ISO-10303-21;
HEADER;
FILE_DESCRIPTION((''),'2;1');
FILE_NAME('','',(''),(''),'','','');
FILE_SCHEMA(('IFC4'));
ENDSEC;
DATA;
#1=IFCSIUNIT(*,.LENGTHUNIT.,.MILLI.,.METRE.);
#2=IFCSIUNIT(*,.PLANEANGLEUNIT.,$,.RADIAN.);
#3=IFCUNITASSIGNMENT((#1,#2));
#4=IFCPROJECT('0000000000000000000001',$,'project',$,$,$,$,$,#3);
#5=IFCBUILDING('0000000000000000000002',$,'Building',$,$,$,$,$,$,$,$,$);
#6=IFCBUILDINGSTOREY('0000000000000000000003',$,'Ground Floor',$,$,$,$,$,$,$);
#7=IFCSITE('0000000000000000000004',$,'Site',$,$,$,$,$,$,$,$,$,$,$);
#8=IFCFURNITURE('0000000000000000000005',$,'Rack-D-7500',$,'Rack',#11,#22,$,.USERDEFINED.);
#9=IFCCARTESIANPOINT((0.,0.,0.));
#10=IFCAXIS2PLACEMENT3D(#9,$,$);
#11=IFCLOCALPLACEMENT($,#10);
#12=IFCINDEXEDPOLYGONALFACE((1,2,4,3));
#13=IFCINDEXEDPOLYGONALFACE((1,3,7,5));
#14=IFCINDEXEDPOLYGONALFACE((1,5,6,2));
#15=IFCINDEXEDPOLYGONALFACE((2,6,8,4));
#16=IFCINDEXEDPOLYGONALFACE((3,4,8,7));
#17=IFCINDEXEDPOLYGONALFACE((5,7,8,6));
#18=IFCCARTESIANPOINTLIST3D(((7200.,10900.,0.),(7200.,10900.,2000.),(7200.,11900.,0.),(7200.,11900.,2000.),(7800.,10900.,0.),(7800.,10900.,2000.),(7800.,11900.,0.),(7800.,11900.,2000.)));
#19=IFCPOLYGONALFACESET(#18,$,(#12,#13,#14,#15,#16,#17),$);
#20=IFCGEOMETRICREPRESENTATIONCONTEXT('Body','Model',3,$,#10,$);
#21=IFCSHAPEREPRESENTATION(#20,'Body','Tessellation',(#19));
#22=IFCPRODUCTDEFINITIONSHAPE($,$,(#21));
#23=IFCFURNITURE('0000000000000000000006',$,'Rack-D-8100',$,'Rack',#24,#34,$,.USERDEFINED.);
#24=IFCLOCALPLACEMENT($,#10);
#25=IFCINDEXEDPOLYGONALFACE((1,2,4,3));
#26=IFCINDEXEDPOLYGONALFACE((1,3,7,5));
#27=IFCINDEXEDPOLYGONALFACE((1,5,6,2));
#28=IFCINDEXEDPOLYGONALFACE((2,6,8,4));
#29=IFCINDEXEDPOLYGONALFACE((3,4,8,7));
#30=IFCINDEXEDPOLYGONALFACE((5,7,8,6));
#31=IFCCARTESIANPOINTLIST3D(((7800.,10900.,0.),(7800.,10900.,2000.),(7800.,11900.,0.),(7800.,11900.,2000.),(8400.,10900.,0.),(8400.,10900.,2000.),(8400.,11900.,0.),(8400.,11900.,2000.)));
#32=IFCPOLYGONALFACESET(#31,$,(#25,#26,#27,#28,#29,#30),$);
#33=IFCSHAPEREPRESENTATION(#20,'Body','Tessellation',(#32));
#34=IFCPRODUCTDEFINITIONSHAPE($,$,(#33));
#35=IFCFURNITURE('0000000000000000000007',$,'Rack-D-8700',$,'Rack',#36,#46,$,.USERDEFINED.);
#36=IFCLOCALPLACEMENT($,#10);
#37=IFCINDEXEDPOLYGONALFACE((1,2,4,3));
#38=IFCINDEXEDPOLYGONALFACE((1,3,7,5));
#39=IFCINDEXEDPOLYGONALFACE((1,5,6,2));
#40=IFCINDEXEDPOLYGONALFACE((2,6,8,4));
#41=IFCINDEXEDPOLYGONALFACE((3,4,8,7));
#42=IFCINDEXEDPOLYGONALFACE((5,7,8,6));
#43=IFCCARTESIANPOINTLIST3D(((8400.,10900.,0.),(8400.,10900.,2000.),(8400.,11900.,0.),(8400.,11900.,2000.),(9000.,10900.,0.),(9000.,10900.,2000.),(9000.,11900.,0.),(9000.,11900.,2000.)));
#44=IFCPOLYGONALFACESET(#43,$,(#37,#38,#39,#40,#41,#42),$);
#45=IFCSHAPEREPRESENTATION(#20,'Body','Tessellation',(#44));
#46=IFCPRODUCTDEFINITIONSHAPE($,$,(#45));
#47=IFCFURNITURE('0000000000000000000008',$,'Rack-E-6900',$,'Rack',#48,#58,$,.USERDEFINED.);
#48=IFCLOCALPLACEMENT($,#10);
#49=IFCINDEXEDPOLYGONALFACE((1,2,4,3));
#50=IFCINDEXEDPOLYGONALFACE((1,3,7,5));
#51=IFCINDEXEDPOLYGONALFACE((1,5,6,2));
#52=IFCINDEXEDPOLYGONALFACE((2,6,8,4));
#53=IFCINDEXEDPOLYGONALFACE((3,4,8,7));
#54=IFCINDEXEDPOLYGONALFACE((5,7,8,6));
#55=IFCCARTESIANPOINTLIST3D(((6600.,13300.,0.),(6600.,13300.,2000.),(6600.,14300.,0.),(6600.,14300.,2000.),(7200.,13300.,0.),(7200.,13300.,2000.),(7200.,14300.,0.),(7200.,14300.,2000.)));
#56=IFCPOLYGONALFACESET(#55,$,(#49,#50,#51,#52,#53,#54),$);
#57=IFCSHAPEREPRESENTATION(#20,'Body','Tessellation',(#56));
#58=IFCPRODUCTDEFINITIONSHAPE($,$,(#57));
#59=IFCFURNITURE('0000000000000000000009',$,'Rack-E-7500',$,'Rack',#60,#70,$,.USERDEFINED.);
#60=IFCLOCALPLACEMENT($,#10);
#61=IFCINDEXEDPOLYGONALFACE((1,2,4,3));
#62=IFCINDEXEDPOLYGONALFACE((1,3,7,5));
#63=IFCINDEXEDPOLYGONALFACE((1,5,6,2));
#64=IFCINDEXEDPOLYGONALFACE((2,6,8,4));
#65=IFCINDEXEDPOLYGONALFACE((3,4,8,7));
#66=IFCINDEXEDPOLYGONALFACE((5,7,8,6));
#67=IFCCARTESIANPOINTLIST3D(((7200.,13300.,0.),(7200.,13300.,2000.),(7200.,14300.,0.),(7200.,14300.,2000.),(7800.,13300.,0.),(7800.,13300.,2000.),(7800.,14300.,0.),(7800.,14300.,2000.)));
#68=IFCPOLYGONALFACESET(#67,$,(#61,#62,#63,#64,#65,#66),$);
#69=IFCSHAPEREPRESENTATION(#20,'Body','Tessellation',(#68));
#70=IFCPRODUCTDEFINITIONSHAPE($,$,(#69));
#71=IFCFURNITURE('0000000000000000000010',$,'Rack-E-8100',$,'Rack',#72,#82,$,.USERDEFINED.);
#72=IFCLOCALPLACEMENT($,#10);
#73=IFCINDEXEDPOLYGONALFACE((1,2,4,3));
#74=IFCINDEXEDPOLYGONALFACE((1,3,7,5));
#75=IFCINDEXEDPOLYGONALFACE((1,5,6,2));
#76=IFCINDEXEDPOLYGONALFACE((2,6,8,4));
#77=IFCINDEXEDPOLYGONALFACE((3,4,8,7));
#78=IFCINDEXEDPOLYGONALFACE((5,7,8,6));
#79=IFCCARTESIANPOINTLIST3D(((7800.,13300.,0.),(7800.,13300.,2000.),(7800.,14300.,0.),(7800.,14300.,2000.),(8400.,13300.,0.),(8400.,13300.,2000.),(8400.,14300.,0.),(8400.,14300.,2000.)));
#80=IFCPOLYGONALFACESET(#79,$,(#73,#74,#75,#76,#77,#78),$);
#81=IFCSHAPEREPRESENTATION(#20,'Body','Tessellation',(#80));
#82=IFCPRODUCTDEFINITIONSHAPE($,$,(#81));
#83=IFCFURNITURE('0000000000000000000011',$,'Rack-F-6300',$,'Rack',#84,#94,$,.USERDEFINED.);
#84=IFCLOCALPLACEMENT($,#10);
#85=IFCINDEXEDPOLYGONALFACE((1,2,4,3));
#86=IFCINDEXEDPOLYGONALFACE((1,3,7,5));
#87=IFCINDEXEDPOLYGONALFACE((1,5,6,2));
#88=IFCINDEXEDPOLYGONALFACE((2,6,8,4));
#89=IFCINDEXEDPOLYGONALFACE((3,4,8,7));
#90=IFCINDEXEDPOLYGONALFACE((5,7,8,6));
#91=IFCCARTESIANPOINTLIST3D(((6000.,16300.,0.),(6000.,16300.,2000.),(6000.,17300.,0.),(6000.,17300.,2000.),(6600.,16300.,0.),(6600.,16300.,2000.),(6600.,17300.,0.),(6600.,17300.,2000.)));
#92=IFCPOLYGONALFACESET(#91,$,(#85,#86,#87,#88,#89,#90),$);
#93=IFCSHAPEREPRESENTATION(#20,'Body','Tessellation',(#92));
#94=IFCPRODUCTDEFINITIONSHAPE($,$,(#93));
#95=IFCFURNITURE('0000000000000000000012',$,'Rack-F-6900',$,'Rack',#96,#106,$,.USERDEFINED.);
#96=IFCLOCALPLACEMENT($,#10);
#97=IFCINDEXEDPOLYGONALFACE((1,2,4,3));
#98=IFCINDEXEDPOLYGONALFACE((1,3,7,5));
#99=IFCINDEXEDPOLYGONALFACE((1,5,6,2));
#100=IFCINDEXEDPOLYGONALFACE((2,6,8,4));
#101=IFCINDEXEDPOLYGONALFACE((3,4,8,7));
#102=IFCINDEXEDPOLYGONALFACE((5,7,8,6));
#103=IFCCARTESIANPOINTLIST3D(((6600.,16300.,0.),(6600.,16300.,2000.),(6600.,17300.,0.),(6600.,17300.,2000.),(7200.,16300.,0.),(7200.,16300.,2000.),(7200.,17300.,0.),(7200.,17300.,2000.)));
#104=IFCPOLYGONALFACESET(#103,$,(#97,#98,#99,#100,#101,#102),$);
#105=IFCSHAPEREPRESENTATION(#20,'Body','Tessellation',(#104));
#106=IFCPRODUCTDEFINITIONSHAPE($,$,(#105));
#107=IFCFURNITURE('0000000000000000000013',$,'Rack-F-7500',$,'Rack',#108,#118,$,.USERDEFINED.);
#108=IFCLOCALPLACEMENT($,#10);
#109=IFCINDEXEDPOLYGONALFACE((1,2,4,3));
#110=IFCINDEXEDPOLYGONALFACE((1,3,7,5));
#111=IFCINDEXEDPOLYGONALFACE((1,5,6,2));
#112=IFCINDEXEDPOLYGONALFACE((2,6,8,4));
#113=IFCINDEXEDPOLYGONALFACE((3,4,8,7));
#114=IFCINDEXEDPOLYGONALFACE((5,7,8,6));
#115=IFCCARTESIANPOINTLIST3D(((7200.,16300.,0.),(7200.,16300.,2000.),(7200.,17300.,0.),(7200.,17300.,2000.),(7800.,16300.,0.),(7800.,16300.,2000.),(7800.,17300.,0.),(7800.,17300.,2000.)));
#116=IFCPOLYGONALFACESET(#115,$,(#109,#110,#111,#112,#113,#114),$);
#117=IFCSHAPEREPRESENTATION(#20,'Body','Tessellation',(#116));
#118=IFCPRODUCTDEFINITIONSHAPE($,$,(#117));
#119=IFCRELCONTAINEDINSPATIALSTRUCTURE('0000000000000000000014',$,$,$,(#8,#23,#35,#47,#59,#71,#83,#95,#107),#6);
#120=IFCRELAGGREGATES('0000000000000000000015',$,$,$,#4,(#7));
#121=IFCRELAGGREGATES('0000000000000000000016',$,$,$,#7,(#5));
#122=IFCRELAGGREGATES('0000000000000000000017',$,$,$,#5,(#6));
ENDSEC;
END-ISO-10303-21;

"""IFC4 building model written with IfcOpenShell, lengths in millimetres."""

from ifc_helpers import new_model, si_unit, frame, origin, place, context, project, spatial, rectangle, extrude, element, save


model = new_model("IFC4")

# Units and contexts
model_context = context("Model", 3, world=origin(), identifier="Body")
ifc_project = project(units=[si_unit("LENGTHUNIT", "METRE", prefix="MILLI"), si_unit("PLANEANGLEUNIT", "RADIAN")])

# Site, building, storey
site = spatial("IfcSite", under=ifc_project, Name="Site")
building = spatial("IfcBuilding", under=site, Name="Building")
storey = spatial("IfcBuildingStorey", under=building, Name="Ground Floor")

# Furniture
for number, where, z_axis, x_axis, name in (
    (1, (7500.0, 11400.0, 0.0), (0.0, 0.0, 1.0), (1.0, 0.0, 0.0), "Rack-D-7500"),
    (2, (8100.0, 11400.0, 0.0), (0.0, 0.0, 1.0), (1.0, 0.0, 0.0), "Rack-D-8100"),
    (3, (8700.0, 11400.0, 0.0), (0.0, 0.0, 1.0), (1.0, 0.0, 0.0), "Rack-D-8700"),
    (4, (6900.0, 13800.0, 0.0), (0.0, 0.0, 1.0), (1.0, 0.0, 0.0), "Rack-E-6900"),
    (5, (7500.0, 13800.0, 0.0), (0.0, 0.0, 1.0), (1.0, 0.0, 0.0), "Rack-E-7500"),
    (6, (8100.0, 13800.0, 0.0), (0.0, 0.0, 1.0), (1.0, 0.0, 0.0), "Rack-E-8100"),
    (7, (6300.0, 16800.0, 0.0), (0.0, 0.0, 1.0), (1.0, 0.0, 0.0), "Rack-F-6300"),
    (8, (6900.0, 16800.0, 0.0), (0.0, 0.0, 1.0), (1.0, 0.0, 0.0), "Rack-F-6900"),
    (9, (7500.0, 16800.0, 0.0), (0.0, 0.0, 1.0), (1.0, 0.0, 0.0), "Rack-F-7500"),
):
    element("IfcFurniture", number, at=place(None, frame(where, z_axis=z_axis, x_axis=x_axis)), inside=storey, Name=name, ObjectType="Rack", PredefinedType="USERDEFINED", context=model_context, shape_type="SweptSolid", body=[
        extrude(rectangle(XDim=600.0, YDim=1000.0), origin(), (0.0, 0.0, 1.0), 2000.0),
    ])

save(model, "model.ifc")
